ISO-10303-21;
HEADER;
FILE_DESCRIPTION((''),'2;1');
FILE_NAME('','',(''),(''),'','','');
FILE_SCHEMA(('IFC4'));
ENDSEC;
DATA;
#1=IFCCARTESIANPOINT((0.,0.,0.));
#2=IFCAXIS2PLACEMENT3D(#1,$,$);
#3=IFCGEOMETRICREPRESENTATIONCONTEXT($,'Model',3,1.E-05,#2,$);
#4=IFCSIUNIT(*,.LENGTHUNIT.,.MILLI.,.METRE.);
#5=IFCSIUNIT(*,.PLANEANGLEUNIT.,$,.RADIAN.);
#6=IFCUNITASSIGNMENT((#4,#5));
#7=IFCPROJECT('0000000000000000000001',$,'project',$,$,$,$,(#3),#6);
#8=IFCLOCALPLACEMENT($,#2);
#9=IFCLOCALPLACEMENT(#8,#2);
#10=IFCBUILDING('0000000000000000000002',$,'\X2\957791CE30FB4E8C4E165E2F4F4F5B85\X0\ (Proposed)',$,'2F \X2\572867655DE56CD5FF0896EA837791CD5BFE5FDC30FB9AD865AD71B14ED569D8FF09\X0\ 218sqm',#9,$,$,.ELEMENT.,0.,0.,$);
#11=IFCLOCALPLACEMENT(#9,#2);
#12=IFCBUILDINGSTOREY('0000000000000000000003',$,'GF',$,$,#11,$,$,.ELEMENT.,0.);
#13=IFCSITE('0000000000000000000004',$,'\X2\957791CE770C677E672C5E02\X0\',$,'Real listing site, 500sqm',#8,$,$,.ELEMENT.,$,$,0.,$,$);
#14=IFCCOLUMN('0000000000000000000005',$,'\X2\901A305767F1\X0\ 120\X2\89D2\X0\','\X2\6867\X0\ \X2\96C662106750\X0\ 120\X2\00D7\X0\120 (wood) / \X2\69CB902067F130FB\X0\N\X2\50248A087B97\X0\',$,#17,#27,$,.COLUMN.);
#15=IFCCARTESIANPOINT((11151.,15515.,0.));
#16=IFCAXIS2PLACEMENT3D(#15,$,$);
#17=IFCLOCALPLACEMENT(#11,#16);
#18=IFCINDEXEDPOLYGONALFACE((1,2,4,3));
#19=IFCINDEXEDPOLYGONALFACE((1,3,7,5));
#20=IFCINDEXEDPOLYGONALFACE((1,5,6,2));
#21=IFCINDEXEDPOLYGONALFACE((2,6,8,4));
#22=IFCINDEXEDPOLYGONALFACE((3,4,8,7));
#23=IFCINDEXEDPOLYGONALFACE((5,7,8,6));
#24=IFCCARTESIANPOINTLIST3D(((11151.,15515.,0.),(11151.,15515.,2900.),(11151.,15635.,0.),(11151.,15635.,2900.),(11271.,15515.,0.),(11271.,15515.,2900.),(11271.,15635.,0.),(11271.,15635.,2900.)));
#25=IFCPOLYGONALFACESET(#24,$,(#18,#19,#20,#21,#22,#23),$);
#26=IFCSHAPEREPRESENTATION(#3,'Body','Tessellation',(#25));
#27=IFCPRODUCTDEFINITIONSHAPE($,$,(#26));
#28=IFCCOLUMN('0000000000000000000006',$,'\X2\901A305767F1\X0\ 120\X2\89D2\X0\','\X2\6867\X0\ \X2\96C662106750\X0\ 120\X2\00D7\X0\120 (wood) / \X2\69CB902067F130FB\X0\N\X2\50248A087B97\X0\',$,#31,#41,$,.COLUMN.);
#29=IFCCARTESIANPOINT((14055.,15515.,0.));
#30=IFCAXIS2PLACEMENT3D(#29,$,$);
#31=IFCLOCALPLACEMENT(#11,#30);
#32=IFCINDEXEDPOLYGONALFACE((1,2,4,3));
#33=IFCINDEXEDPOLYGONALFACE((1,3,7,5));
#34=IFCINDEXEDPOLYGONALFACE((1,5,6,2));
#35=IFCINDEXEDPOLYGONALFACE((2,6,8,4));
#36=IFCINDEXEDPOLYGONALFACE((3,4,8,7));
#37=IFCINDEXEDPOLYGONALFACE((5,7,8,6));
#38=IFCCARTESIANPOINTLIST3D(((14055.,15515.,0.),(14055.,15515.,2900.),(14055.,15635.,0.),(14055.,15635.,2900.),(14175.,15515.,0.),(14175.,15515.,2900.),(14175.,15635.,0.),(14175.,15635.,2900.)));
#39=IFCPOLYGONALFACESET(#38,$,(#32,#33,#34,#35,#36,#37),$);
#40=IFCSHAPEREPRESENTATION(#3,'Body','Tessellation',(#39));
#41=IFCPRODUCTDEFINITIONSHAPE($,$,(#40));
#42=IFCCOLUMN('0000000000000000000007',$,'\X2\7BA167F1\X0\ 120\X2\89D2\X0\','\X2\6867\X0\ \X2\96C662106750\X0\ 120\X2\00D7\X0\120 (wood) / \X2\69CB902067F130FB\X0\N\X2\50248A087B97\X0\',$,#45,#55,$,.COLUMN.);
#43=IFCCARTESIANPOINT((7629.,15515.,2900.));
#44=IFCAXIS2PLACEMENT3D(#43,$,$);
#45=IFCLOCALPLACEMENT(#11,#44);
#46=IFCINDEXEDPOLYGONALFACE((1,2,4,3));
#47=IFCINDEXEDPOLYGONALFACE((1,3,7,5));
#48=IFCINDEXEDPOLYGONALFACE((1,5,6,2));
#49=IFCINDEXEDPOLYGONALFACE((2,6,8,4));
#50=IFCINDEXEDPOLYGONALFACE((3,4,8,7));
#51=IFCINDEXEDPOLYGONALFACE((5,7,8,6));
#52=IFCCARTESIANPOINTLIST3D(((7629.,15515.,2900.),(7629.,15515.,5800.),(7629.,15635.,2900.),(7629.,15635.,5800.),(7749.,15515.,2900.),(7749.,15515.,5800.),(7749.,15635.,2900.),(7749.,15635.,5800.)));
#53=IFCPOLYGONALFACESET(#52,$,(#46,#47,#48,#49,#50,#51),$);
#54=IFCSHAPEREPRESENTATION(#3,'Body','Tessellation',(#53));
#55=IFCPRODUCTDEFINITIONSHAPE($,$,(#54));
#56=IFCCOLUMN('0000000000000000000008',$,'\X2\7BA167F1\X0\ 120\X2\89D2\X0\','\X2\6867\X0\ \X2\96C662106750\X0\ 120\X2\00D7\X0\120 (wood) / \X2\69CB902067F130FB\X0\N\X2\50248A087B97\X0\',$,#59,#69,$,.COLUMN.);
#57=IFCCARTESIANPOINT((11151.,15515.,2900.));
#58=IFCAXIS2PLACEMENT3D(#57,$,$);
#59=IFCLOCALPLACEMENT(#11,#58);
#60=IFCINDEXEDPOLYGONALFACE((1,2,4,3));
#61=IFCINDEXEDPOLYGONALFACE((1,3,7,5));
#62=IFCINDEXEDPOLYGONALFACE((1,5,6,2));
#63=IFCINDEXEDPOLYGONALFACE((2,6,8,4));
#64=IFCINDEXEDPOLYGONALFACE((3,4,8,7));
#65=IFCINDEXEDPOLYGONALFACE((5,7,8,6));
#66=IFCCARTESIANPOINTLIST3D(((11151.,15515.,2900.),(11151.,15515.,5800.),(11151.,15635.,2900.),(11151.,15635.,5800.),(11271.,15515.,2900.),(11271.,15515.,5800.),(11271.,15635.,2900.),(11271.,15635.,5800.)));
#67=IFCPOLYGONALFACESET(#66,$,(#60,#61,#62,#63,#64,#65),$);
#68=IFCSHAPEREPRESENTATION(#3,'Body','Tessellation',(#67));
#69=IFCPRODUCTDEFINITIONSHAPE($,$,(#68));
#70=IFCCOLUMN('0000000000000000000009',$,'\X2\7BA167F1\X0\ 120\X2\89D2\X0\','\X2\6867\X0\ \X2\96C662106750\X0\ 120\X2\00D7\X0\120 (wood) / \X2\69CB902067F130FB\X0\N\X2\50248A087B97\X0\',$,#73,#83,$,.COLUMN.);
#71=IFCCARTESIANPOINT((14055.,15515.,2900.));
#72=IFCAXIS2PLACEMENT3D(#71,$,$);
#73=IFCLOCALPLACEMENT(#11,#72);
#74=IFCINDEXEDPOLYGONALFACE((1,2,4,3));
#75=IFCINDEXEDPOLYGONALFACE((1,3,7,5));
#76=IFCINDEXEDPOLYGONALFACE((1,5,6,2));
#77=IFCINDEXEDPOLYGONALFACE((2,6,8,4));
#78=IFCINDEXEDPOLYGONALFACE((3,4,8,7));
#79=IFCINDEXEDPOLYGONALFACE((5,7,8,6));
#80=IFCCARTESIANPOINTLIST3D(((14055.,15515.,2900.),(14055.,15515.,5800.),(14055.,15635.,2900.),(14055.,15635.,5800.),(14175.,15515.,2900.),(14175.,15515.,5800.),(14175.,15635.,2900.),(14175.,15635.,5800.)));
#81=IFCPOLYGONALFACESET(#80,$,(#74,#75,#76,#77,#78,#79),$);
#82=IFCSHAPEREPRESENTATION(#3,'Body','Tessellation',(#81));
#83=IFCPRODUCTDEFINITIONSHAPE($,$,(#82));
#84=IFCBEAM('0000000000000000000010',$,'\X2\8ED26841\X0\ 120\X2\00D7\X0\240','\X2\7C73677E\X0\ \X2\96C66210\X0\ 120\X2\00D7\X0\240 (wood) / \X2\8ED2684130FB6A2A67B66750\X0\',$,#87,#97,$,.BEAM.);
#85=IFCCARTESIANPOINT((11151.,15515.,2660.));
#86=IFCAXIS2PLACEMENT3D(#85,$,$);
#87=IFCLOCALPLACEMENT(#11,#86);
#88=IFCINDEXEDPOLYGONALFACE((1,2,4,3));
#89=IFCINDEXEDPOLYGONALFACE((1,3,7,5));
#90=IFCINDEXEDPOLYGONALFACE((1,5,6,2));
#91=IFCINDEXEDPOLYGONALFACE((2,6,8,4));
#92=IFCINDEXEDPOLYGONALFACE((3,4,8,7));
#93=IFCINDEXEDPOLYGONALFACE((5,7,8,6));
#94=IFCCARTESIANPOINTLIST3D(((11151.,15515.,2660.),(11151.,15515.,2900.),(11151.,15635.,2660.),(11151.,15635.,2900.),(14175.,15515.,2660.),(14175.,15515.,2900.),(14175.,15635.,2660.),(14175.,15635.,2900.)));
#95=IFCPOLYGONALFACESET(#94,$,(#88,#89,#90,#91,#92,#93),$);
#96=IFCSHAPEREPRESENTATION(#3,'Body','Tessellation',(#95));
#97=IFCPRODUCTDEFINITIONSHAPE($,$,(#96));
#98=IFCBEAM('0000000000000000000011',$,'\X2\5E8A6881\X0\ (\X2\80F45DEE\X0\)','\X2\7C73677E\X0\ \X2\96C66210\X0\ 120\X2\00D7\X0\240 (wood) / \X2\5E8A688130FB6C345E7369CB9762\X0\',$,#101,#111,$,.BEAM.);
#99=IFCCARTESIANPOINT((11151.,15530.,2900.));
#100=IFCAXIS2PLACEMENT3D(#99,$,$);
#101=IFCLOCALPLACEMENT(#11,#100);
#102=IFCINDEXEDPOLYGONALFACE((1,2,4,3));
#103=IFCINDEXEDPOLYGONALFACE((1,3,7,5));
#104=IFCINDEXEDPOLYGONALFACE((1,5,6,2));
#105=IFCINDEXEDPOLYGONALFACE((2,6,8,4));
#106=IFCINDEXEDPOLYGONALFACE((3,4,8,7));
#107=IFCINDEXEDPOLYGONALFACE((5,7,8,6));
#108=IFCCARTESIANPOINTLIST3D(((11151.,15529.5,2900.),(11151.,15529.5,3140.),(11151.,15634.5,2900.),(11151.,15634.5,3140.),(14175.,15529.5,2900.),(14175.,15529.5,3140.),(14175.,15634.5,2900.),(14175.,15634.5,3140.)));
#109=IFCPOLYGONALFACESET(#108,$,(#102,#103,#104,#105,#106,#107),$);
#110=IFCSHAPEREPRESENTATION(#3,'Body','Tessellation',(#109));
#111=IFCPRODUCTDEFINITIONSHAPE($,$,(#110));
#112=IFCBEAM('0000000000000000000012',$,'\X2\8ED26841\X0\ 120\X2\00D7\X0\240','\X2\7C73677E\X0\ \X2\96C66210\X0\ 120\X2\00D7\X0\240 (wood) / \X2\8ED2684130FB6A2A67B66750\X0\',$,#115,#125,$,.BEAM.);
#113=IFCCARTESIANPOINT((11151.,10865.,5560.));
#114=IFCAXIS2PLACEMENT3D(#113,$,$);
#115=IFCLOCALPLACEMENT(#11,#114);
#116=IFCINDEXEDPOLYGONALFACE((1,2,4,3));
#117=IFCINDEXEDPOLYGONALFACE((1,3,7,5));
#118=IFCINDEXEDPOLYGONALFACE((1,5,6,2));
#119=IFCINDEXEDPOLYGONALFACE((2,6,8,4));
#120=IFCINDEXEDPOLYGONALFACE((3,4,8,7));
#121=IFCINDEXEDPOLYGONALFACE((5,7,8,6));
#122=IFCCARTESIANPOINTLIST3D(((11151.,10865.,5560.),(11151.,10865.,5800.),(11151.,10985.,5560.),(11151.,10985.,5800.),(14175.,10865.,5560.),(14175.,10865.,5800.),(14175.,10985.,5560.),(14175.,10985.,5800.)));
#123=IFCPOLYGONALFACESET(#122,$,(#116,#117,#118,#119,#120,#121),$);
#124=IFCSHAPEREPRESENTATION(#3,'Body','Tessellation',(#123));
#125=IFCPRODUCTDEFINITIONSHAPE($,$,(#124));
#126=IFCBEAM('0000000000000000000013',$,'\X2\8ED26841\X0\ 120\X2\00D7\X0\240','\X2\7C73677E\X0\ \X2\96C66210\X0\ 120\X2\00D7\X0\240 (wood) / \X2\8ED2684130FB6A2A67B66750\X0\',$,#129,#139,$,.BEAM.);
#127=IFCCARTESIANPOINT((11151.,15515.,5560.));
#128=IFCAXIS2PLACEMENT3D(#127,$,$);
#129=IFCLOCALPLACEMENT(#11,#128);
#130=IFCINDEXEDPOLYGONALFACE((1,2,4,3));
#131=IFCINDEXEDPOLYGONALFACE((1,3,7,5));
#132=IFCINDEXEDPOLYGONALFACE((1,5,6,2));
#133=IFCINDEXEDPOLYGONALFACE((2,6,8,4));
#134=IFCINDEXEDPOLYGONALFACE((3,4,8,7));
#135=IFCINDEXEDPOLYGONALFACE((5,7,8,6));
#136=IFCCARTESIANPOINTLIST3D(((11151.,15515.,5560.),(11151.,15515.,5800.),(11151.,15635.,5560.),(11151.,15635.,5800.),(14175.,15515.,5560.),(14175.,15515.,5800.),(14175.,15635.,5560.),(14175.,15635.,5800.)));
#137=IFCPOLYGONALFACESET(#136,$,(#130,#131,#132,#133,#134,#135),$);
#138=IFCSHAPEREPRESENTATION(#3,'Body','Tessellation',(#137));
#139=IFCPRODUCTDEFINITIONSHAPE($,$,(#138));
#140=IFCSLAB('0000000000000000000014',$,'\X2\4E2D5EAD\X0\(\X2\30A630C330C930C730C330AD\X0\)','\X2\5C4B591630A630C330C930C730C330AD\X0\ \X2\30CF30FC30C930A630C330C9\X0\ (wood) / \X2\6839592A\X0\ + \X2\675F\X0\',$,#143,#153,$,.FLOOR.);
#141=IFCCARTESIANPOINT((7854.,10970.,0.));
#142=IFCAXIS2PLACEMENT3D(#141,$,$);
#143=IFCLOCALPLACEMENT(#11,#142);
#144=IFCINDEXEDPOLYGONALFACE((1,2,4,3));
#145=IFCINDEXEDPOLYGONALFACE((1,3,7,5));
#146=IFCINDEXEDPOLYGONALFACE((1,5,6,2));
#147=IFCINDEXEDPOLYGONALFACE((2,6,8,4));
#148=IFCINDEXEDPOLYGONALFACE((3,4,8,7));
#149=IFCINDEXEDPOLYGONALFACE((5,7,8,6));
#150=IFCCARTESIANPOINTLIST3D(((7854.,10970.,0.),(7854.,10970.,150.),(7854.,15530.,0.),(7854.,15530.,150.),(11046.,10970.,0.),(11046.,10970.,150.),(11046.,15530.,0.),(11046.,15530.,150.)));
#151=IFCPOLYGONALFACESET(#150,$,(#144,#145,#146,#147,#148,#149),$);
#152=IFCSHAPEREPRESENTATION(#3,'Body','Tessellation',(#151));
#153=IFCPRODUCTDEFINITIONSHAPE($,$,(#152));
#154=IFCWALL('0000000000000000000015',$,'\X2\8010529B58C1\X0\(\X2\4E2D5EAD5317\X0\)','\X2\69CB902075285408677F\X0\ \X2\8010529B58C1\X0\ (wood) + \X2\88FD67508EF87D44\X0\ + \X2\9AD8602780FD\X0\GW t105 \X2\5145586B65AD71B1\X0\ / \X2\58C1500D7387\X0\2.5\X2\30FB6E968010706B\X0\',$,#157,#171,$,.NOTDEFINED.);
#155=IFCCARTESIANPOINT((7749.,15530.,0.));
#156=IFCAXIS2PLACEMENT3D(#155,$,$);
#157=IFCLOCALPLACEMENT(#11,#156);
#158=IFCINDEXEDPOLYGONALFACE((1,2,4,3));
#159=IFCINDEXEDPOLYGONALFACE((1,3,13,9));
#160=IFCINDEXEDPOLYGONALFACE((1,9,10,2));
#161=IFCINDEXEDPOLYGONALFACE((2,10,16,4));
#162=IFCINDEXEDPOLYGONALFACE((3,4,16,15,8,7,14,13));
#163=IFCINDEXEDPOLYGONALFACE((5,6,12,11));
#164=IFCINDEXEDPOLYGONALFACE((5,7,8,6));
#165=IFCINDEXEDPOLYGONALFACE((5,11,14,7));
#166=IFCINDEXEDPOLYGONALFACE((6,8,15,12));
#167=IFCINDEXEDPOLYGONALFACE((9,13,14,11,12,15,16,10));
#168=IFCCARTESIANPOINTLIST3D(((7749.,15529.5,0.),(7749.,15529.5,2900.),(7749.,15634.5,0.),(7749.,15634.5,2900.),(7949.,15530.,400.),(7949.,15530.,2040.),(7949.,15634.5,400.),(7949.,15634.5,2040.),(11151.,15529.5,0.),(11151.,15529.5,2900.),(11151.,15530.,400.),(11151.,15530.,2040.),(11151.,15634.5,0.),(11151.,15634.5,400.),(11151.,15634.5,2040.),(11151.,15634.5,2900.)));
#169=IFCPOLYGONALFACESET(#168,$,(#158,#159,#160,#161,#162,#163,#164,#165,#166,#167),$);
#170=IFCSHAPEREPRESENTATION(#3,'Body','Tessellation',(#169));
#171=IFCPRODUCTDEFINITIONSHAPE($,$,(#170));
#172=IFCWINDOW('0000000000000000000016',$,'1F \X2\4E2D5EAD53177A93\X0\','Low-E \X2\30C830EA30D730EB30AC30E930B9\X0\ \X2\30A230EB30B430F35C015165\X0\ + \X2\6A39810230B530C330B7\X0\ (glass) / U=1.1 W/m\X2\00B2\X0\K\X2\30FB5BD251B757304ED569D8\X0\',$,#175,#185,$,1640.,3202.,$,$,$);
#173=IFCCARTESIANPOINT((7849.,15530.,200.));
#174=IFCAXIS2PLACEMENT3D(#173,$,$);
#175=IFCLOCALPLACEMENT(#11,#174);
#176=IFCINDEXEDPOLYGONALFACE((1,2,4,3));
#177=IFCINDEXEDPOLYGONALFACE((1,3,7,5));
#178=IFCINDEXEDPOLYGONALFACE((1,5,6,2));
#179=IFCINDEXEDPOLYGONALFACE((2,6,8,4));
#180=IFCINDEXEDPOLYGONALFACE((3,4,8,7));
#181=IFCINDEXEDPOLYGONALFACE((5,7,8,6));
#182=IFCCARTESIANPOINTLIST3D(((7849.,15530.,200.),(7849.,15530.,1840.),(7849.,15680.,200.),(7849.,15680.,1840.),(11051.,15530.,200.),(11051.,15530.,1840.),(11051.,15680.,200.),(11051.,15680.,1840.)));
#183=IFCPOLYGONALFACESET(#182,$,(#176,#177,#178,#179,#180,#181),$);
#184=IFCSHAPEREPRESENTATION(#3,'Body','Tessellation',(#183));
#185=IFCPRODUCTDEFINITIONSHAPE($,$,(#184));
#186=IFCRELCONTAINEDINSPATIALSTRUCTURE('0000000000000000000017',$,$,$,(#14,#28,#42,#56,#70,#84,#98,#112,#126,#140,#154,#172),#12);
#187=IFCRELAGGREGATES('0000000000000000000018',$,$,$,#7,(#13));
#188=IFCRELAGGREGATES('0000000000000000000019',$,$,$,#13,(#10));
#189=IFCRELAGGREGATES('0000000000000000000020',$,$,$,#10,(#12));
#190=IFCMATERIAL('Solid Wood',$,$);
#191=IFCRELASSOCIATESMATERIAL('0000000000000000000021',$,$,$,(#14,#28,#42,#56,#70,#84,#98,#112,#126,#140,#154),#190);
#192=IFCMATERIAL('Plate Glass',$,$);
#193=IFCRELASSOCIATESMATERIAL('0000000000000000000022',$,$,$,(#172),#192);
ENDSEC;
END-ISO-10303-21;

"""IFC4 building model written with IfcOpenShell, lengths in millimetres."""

from ifc_helpers import new_model, si_unit, frame, frame_2d, origin, place, context, project, spatial, rectangle, extrude, material, element, fill, save


model = new_model("IFC4")

# Units and contexts
model_context = context("Model", 3, precision=1e-05, world=origin())
ifc_project = project(units=[si_unit("LENGTHUNIT", "METRE", prefix="MILLI"), si_unit("PLANEANGLEUNIT", "RADIAN")], contexts=[model_context])

# Site, building, storey
site_placement = place(None, origin())
site = spatial("IfcSite", under=ifc_project, at=site_placement, Name="長野県松本市", ObjectType="Real listing site, 500sqm", CompositionType="ELEMENT", RefElevation=0.0)
building_placement = place(site_placement, origin())
building = spatial("IfcBuilding", under=site, at=building_placement, Name="長野・二世帯住宅 (Proposed)", ObjectType="2F 在来工法（雪荷重対応・高断熱仕様） 218sqm", CompositionType="ELEMENT", ElevationOfRefHeight=0.0, ElevationOfTerrain=0.0)
storey_placement = place(building_placement, origin())
storey = spatial("IfcBuildingStorey", under=building, at=storey_placement, Name="GF", CompositionType="ELEMENT", Elevation=0.0)

# Columns
ifc_material_1 = material(Name="Solid Wood")
column_1_placement = place(storey_placement, frame((11151.0, 15515.0, 0.0)))
element("IfcColumn", 1, at=column_1_placement, inside=storey, material=ifc_material_1, Name="通し柱 120角", Description="桧 集成材 120×120 (wood) / 構造柱・N値計算", PredefinedType="COLUMN", context=model_context, shape_type="SweptSolid", body=[
    extrude(rectangle(XDim=120.0, YDim=120.0, at=frame_2d((60.0, 60.0))), frame((11151.0, 15515.0, 0.0)), (0.0, 0.0, 1.0), 2900.0),
])
column_2_placement = place(storey_placement, frame((14055.0, 15515.0, 0.0)))
element("IfcColumn", 2, at=column_2_placement, inside=storey, material=ifc_material_1, Name="通し柱 120角", Description="桧 集成材 120×120 (wood) / 構造柱・N値計算", PredefinedType="COLUMN", context=model_context, shape_type="SweptSolid", body=[
    extrude(rectangle(XDim=120.0, YDim=120.0, at=frame_2d((60.0, 60.0))), frame((14055.0, 15515.0, 0.0)), (0.0, 0.0, 1.0), 2900.0),
])
column_3_placement = place(storey_placement, frame((7629.0, 15515.0, 2900.0)))
element("IfcColumn", 3, at=column_3_placement, inside=storey, material=ifc_material_1, Name="管柱 120角", Description="桧 集成材 120×120 (wood) / 構造柱・N値計算", PredefinedType="COLUMN", context=model_context, shape_type="SweptSolid", body=[
    extrude(rectangle(XDim=120.0, YDim=120.0, at=frame_2d((60.0, 60.0))), frame((7629.0, 15515.0, 2900.0)), (0.0, 0.0, 1.0), 2900.0),
])
column_4_placement = place(storey_placement, frame((11151.0, 15515.0, 2900.0)))
element("IfcColumn", 4, at=column_4_placement, inside=storey, material=ifc_material_1, Name="管柱 120角", Description="桧 集成材 120×120 (wood) / 構造柱・N値計算", PredefinedType="COLUMN", context=model_context, shape_type="SweptSolid", body=[
    extrude(rectangle(XDim=120.0, YDim=120.0, at=frame_2d((60.0, 60.0))), frame((11151.0, 15515.0, 2900.0)), (0.0, 0.0, 1.0), 2900.0),
])
column_5_placement = place(storey_placement, frame((14055.0, 15515.0, 2900.0)))
element("IfcColumn", 5, at=column_5_placement, inside=storey, material=ifc_material_1, Name="管柱 120角", Description="桧 集成材 120×120 (wood) / 構造柱・N値計算", PredefinedType="COLUMN", context=model_context, shape_type="SweptSolid", body=[
    extrude(rectangle(XDim=120.0, YDim=120.0, at=frame_2d((60.0, 60.0))), frame((14055.0, 15515.0, 2900.0)), (0.0, 0.0, 1.0), 2900.0),
])

# Beams
beam_1_placement = place(storey_placement, frame((11151.0, 15515.0, 2660.0)))
element("IfcBeam", 6, at=beam_1_placement, inside=storey, material=ifc_material_1, Name="軒桁 120×240", Description="米松 集成 120×240 (wood) / 軒桁・横架材", PredefinedType="BEAM", context=model_context, shape_type="SweptSolid", body=[
    extrude(rectangle(XDim=3024.0, YDim=120.0, at=frame_2d((1512.0, 60.0))), frame((11151.0, 15515.0, 2660.0)), (0.0, 0.0, 1.0), 240.0),
])
beam_2_placement = place(storey_placement, frame((11151.0, 15530.0, 2900.0)))
element("IfcBeam", 7, at=beam_2_placement, inside=storey, material=ifc_material_1, Name="床梁 (胴差)", Description="米松 集成 120×240 (wood) / 床梁・水平構面", PredefinedType="BEAM", context=model_context, shape_type="SweptSolid", body=[
    extrude(rectangle(XDim=3024.0, YDim=105.0, at=frame_2d((1512.0, 52.0))), frame((11151.0, 15530.0, 2900.0)), (0.0, 0.0, 1.0), 240.0),
])
beam_3_placement = place(storey_placement, frame((11151.0, 10865.0, 5560.0)))
element("IfcBeam", 8, at=beam_3_placement, inside=storey, material=ifc_material_1, Name="軒桁 120×240", Description="米松 集成 120×240 (wood) / 軒桁・横架材", PredefinedType="BEAM", context=model_context, shape_type="SweptSolid", body=[
    extrude(rectangle(XDim=3024.0, YDim=120.0, at=frame_2d((1512.0, 60.0))), frame((11151.0, 10865.0, 5560.0)), (0.0, 0.0, 1.0), 240.0),
])
beam_4_placement = place(storey_placement, frame((11151.0, 15515.0, 5560.0)))
element("IfcBeam", 9, at=beam_4_placement, inside=storey, material=ifc_material_1, Name="軒桁 120×240", Description="米松 集成 120×240 (wood) / 軒桁・横架材", PredefinedType="BEAM", context=model_context, shape_type="SweptSolid", body=[
    extrude(rectangle(XDim=3024.0, YDim=120.0, at=frame_2d((1512.0, 60.0))), frame((11151.0, 15515.0, 5560.0)), (0.0, 0.0, 1.0), 240.0),
])

# Slab
slab_placement = place(storey_placement, frame((7854.0, 10970.0, 0.0)))
element("IfcSlab", 10, at=slab_placement, inside=storey, material=ifc_material_1, Name="中庭(ウッドデッキ)", Description="屋外ウッドデッキ ハードウッド (wood) / 根太 + 束", PredefinedType="FLOOR", context=model_context, shape_type="SweptSolid", body=[
    extrude(rectangle(XDim=3192.0, YDim=4560.0, at=frame_2d((1596.0, 2280.0))), frame((7854.0, 10970.0, 0.0)), (0.0, 0.0, 1.0), 150.0),
])

# Wall, opening, window
wall_1_placement = place(storey_placement, frame((7749.0, 15530.0, 0.0)))
wall_1 = element("IfcWall", 11, at=wall_1_placement, inside=storey, material=ifc_material_1, Name="耐力壁(中庭北)", Description="構造用合板 耐力壁 (wood) + 製材軸組 + 高性能GW t105 充填断熱 / 壁倍率2.5・準耐火", PredefinedType="NOTDEFINED", context=model_context, shape_type="SweptSolid", body=[
    extrude(rectangle(XDim=3402.0, YDim=105.0, at=frame_2d((1701.0, 52.0))), frame((7749.0, 15530.0, 0.0)), (0.0, 0.0, 1.0), 2900.0),
])
opening_1_placement = place(storey_placement, frame((7849.0, 15530.0, 200.0)))
opening_1 = element("IfcOpeningElement", 12, at=opening_1_placement, cuts=wall_1, PredefinedType="NOTDEFINED", context=model_context, shape_type="SweptSolid", body=[
    extrude(rectangle(XDim=3202.0, YDim=150.0, at=frame_2d((1601.0, 75.0))), frame((7849.0, 15530.0, 200.0)), (0.0, 0.0, 1.0), 1640.0),
])
ifc_material_2 = material(Name="Plate Glass")
window_1_placement = place(storey_placement, frame((7849.0, 15530.0, 200.0)))
window_1 = element("IfcWindow", 13, at=window_1_placement, inside=storey, material=ifc_material_2, Name="1F 中庭北窓", Description="Low-E トリプルガラス アルゴン封入 + 樹脂サッシ (glass) / U=1.1 W/m²K・寒冷地仕様", OverallHeight=1640.0, OverallWidth=3202.0, context=model_context, shape_type="SweptSolid", body=[
    extrude(rectangle(XDim=3202.0, YDim=150.0, at=frame_2d((1601.0, 75.0))), frame((7849.0, 15530.0, 200.0)), (0.0, 0.0, 1.0), 1640.0),
])
fill(opening_1, window_1)

save(model, "model.ifc")
